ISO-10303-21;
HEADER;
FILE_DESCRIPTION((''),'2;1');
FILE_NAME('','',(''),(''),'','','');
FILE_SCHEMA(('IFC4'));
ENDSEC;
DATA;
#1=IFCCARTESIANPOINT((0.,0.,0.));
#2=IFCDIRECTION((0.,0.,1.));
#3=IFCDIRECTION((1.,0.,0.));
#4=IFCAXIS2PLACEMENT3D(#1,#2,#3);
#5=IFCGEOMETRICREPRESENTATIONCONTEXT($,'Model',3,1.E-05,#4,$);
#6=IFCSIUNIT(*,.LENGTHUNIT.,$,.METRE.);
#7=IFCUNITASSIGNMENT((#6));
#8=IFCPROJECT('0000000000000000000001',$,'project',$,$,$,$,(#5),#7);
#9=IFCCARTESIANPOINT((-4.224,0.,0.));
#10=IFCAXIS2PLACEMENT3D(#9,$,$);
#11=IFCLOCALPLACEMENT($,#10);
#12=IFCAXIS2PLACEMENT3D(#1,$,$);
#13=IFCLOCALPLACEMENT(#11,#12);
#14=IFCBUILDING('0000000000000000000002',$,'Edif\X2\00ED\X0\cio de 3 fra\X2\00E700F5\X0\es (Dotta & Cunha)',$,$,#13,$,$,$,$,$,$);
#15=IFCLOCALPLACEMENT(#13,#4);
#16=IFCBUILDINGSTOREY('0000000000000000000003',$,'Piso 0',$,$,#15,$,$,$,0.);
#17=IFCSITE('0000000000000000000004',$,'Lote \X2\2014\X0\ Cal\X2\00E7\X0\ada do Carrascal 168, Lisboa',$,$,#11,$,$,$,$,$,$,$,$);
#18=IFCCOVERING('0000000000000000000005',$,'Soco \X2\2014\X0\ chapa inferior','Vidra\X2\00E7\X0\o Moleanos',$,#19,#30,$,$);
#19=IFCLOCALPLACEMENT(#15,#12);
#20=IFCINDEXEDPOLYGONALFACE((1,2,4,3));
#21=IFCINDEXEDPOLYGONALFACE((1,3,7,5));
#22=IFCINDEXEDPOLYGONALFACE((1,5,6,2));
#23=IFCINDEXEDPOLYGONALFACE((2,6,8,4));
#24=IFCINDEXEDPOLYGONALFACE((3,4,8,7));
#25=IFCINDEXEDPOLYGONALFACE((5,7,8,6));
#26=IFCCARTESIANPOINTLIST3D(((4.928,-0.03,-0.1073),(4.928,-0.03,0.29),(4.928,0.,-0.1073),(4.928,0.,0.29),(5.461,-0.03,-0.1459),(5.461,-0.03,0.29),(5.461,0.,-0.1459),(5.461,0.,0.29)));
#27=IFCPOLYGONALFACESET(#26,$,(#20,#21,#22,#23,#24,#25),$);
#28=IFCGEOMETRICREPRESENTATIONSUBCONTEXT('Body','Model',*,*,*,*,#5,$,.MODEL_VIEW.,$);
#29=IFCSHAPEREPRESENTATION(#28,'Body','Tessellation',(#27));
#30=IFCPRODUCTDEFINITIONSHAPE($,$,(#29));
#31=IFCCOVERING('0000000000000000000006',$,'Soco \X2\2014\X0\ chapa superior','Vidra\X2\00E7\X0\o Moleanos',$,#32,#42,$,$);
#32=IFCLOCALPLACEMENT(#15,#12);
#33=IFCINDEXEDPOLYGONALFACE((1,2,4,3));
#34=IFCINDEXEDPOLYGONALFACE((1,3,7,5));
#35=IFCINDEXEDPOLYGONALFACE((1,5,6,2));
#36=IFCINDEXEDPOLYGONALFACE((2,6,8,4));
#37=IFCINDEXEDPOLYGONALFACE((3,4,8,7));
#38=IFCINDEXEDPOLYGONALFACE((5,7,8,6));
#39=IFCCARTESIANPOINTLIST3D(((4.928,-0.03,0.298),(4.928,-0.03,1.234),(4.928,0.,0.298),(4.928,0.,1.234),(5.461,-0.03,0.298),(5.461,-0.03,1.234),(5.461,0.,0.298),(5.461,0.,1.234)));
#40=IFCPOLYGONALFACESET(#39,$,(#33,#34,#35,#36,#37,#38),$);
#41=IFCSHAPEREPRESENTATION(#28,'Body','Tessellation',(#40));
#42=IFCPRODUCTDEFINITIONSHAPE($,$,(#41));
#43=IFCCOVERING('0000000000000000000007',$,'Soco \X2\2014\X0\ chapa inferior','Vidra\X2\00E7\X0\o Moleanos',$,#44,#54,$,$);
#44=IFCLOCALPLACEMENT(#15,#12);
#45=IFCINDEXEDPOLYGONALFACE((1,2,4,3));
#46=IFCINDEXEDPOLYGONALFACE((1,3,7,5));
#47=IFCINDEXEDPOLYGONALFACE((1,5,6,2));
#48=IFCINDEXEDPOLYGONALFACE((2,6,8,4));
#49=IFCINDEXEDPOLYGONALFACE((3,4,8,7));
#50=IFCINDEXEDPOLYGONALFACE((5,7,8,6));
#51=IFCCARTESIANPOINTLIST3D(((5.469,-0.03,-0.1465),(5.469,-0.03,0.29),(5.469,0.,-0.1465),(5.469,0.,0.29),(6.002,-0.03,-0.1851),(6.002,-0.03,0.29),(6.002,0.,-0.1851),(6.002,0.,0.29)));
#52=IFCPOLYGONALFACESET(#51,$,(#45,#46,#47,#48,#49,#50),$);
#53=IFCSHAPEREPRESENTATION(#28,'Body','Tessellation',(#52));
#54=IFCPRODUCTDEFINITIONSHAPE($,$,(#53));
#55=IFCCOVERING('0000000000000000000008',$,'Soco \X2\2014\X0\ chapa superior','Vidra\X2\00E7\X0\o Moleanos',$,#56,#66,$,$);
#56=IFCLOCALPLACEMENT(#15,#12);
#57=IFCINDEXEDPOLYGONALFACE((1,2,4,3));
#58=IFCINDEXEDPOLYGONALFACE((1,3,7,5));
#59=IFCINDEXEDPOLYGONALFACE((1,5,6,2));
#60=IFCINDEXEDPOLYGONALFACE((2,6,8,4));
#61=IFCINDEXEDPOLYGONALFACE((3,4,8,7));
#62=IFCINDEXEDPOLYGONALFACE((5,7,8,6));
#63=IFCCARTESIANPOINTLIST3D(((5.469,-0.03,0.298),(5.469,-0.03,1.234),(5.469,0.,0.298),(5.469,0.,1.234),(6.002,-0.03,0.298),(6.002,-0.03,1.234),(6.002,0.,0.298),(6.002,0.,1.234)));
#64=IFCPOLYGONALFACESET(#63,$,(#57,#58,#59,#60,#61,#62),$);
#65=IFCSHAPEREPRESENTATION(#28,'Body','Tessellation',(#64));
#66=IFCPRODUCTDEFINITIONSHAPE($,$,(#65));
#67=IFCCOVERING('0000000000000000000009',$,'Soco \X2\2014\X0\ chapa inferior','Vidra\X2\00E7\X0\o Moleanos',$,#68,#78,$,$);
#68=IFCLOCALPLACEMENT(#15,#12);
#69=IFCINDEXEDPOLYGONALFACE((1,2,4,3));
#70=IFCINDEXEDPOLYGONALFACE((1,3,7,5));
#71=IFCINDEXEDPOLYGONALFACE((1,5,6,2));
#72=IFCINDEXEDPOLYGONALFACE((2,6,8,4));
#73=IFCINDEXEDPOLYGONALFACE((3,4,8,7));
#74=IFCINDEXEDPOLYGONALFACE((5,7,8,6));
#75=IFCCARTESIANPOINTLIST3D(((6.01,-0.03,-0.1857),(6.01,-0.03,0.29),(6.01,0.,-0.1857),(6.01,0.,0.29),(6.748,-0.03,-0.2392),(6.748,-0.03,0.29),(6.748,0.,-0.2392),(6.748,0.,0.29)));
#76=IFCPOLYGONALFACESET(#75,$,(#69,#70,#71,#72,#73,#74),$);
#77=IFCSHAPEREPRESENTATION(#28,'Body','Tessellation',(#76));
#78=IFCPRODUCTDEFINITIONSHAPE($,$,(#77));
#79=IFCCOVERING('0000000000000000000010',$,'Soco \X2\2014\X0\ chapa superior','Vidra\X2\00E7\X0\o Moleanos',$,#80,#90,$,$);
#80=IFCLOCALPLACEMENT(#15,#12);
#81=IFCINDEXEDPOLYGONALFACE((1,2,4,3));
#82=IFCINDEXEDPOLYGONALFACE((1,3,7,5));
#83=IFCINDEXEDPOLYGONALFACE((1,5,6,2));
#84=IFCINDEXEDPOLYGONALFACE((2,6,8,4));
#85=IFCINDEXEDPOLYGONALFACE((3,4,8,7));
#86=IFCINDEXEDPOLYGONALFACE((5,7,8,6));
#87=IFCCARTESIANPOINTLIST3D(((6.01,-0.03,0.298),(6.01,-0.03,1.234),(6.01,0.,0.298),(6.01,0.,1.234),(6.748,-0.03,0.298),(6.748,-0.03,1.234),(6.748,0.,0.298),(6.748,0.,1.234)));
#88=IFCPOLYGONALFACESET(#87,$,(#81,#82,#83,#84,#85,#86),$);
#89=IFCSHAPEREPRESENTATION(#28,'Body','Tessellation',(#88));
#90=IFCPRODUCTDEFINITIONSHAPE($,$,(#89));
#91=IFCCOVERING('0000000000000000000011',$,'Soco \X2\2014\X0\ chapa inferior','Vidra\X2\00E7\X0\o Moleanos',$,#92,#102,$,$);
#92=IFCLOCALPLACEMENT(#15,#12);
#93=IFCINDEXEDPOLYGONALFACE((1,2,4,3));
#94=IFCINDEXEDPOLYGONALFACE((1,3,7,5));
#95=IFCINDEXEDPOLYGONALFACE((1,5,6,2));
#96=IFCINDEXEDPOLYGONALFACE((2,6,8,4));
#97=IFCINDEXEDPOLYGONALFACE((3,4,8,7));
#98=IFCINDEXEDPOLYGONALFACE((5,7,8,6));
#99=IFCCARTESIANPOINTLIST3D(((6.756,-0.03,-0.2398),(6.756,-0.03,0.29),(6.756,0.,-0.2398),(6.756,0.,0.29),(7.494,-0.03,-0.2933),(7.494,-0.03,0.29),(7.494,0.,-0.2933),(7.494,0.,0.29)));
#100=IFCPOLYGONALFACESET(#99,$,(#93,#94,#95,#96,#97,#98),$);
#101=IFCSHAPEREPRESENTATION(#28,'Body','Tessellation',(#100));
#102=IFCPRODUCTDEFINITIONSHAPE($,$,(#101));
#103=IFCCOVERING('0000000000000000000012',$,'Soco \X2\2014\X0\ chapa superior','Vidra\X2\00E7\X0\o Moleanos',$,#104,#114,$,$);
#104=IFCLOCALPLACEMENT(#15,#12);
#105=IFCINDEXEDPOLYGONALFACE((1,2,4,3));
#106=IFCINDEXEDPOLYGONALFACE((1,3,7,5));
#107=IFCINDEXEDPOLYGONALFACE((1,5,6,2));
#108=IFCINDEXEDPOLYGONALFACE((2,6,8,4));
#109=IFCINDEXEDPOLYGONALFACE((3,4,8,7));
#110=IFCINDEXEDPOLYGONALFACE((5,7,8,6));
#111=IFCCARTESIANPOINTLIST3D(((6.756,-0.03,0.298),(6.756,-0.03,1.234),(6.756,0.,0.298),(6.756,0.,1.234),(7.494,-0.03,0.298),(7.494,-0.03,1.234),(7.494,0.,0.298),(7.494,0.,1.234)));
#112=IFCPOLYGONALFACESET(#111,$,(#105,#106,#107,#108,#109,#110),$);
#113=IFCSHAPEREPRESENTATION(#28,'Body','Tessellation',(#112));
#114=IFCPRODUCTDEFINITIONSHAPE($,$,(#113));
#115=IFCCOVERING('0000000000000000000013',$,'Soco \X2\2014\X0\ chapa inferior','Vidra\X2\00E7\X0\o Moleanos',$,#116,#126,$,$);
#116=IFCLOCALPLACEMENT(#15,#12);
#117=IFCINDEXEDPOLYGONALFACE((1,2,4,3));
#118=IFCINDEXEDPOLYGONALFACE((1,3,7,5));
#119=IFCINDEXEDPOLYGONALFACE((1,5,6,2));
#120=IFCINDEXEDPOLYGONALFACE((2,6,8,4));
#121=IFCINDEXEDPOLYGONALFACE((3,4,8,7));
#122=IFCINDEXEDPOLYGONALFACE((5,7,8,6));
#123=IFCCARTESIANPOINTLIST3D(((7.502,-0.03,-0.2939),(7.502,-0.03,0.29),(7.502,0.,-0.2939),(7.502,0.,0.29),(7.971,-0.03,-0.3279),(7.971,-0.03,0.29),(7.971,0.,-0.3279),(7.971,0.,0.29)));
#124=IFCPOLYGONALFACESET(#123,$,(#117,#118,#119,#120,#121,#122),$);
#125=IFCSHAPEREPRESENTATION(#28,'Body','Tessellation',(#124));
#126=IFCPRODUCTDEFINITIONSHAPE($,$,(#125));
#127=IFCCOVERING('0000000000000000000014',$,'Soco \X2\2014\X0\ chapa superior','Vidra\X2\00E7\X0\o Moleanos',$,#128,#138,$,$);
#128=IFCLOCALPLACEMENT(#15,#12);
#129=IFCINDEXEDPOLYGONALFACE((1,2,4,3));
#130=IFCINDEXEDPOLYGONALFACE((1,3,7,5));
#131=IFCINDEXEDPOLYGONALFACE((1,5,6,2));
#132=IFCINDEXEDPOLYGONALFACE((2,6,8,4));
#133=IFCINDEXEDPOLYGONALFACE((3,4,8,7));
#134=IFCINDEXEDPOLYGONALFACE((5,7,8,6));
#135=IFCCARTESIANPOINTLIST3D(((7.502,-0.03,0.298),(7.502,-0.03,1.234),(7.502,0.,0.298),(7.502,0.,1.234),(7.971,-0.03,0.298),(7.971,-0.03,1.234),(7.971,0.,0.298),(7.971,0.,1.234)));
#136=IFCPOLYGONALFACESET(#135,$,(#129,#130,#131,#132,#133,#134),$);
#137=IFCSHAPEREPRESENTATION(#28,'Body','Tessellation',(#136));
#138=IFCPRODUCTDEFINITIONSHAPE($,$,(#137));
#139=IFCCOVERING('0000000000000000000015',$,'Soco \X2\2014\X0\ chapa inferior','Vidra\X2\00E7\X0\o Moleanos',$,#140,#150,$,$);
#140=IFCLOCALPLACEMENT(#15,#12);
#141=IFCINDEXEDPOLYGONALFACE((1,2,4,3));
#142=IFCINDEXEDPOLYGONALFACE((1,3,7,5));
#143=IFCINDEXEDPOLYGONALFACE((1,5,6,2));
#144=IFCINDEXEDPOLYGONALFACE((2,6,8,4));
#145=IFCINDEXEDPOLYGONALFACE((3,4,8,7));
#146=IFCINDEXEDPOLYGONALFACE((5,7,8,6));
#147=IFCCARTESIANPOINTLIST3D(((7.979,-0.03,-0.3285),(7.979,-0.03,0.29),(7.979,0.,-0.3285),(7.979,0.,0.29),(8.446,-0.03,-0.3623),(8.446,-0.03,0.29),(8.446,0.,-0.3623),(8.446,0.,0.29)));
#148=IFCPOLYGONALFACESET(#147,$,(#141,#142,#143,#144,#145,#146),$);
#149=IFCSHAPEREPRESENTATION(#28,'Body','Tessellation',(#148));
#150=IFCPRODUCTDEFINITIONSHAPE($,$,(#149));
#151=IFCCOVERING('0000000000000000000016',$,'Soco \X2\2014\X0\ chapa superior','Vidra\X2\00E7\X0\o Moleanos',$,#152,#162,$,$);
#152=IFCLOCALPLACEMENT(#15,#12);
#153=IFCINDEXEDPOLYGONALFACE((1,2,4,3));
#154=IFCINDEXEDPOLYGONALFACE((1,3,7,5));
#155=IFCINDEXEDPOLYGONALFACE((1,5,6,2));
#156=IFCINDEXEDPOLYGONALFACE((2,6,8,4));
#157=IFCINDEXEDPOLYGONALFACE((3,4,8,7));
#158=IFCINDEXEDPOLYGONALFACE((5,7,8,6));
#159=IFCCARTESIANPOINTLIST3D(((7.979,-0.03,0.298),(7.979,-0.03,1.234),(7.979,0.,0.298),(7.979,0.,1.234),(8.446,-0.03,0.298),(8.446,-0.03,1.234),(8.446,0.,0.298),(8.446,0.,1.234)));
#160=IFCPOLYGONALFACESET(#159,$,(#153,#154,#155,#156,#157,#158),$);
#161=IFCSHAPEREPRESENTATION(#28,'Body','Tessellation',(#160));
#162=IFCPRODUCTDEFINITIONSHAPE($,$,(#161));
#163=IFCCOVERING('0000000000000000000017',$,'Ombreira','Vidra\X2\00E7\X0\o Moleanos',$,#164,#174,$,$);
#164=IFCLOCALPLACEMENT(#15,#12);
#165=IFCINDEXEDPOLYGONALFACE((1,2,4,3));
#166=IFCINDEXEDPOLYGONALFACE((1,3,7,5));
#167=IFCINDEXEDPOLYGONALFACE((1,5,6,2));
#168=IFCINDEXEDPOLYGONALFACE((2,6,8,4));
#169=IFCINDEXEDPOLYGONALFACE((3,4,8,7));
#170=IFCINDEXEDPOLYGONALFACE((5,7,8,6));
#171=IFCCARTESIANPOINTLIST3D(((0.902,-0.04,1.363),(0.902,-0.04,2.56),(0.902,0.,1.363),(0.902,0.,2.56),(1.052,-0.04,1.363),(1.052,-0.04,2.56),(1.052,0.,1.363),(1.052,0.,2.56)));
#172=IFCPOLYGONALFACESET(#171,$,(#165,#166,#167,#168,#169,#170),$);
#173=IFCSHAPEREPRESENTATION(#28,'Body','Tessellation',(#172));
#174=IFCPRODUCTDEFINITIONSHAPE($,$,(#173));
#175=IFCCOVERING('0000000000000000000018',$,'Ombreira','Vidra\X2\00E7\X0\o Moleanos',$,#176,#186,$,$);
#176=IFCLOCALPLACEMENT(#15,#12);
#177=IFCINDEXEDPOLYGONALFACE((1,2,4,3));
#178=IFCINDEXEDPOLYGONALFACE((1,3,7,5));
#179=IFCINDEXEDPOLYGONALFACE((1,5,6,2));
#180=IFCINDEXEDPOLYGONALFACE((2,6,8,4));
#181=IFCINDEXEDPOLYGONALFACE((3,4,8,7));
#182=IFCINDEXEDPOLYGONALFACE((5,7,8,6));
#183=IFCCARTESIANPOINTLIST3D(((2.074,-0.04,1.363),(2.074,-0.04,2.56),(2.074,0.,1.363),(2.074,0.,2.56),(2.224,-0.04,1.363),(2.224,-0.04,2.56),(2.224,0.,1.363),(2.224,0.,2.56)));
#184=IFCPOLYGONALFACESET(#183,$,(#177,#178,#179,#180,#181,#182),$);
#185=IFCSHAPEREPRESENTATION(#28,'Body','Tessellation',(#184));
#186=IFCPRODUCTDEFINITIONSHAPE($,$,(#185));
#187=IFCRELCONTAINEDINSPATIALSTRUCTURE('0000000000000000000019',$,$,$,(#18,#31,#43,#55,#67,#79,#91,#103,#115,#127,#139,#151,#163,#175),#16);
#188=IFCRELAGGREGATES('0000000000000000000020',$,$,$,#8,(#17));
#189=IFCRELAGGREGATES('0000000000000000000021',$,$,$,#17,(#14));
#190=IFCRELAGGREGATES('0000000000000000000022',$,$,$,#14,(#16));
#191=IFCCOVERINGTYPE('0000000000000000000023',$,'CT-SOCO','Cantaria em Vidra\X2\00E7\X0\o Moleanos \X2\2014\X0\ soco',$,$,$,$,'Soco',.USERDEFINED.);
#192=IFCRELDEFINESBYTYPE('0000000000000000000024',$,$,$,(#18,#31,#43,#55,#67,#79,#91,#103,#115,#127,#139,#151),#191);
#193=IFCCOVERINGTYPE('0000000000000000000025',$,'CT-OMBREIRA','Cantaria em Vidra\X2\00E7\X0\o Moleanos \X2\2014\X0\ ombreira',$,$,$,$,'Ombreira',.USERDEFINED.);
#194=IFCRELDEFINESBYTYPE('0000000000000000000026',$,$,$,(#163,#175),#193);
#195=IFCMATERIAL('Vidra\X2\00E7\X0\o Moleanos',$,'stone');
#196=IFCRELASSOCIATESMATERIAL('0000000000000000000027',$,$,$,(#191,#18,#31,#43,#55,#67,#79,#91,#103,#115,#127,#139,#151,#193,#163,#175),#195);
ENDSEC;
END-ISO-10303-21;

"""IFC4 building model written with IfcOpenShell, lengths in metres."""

from ifc_helpers import new_model, si_unit, frame, origin, origin_with_axes, place, context, subcontext, project, spatial, line, indexed_curve, outline, extrude, material, type_object, element, save


model = new_model("IFC4")

# Units and contexts
model_context = context("Model", 3, precision=1e-05, world=origin_with_axes())
body_context = subcontext(model_context, "Body", "Model", "MODEL_VIEW")
ifc_project = project(units=[si_unit("LENGTHUNIT", "METRE")], contexts=[model_context])

# Site, building, storey
site_placement = place(None, frame((-4.224, 0.0, 0.0)))
site = spatial("IfcSite", under=ifc_project, at=site_placement, Name="Lote — Calçada do Carrascal 168, Lisboa")
building_placement = place(site_placement, origin())
building = spatial("IfcBuilding", under=site, at=building_placement, Name="Edifício de 3 frações (Dotta & Cunha)")
storey_placement = place(building_placement, origin_with_axes())
storey = spatial("IfcBuildingStorey", under=building, at=storey_placement, Name="Piso 0", Elevation=0.0)

# Coverings
ifc_material = material(Name="Vidraço Moleanos", Category="stone")
covering_type_1 = type_object("IfcCoveringType", Name="CT-SOCO", Description="Cantaria em Vidraço Moleanos — soco", ElementType="Soco", PredefinedType="USERDEFINED", material=ifc_material)
covering_1_placement = place(storey_placement, frame((0.0, 0.0, 0.0), z_axis=(0.0, -1.0, 0.0), x_axis=(1.0, 0.0, 0.0)))
element("IfcCovering", 1, at=covering_1_placement, inside=storey, type_object=covering_type_1, material=ifc_material, Name="Soco — chapa inferior", Description="Vidraço Moleanos", context=body_context, shape_type="SweptSolid", body=[
    extrude(outline(indexed_curve([(4.928, -0.1073), (5.461, -0.1459), (5.461, 0.29), (4.928, 0.29)], segments=[line(1, 2, 3, 4, 1)])), origin_with_axes(), (0.0, 0.0, 1.0), 0.03),
])
covering_2_placement = place(storey_placement, frame((0.0, 0.0, 0.0), z_axis=(0.0, -1.0, 0.0), x_axis=(1.0, 0.0, 0.0)))
element("IfcCovering", 2, at=covering_2_placement, inside=storey, type_object=covering_type_1, material=ifc_material, Name="Soco — chapa superior", Description="Vidraço Moleanos", context=body_context, shape_type="SweptSolid", body=[
    extrude(outline(indexed_curve([(5.461, 0.298), (5.461, 1.234), (4.928, 1.234), (4.928, 0.298)], segments=[line(1, 2, 3, 4, 1)])), origin_with_axes(), (0.0, 0.0, 1.0), 0.03),
])
covering_3_placement = place(storey_placement, frame((0.0, 0.0, 0.0), z_axis=(0.0, -1.0, 0.0), x_axis=(1.0, 0.0, 0.0)))
element("IfcCovering", 3, at=covering_3_placement, inside=storey, type_object=covering_type_1, material=ifc_material, Name="Soco — chapa inferior", Description="Vidraço Moleanos", context=body_context, shape_type="SweptSolid", body=[
    extrude(outline(indexed_curve([(5.469, -0.1465), (6.002, -0.1851), (6.002, 0.29), (5.469, 0.29)], segments=[line(1, 2, 3, 4, 1)])), origin_with_axes(), (0.0, 0.0, 1.0), 0.03),
])
covering_4_placement = place(storey_placement, frame((0.0, 0.0, 0.0), z_axis=(0.0, -1.0, 0.0), x_axis=(1.0, 0.0, 0.0)))
element("IfcCovering", 4, at=covering_4_placement, inside=storey, type_object=covering_type_1, material=ifc_material, Name="Soco — chapa superior", Description="Vidraço Moleanos", context=body_context, shape_type="SweptSolid", body=[
    extrude(outline(indexed_curve([(6.002, 0.298), (6.002, 1.234), (5.469, 1.234), (5.469, 0.298)], segments=[line(1, 2, 3, 4, 1)])), origin_with_axes(), (0.0, 0.0, 1.0), 0.03),
])
covering_5_placement = place(storey_placement, frame((0.0, 0.0, 0.0), z_axis=(0.0, -1.0, 0.0), x_axis=(1.0, 0.0, 0.0)))
element("IfcCovering", 5, at=covering_5_placement, inside=storey, type_object=covering_type_1, material=ifc_material, Name="Soco — chapa inferior", Description="Vidraço Moleanos", context=body_context, shape_type="SweptSolid", body=[
    extrude(outline(indexed_curve([(6.01, -0.1857), (6.748, -0.2392), (6.748, 0.29), (6.01, 0.29)], segments=[line(1, 2, 3, 4, 1)])), origin_with_axes(), (0.0, 0.0, 1.0), 0.03),
])
covering_6_placement = place(storey_placement, frame((0.0, 0.0, 0.0), z_axis=(0.0, -1.0, 0.0), x_axis=(1.0, 0.0, 0.0)))
element("IfcCovering", 6, at=covering_6_placement, inside=storey, type_object=covering_type_1, material=ifc_material, Name="Soco — chapa superior", Description="Vidraço Moleanos", context=body_context, shape_type="SweptSolid", body=[
    extrude(outline(indexed_curve([(6.748, 0.298), (6.748, 1.234), (6.01, 1.234), (6.01, 0.298)], segments=[line(1, 2, 3, 4, 1)])), origin_with_axes(), (0.0, 0.0, 1.0), 0.03),
])
covering_7_placement = place(storey_placement, frame((0.0, 0.0, 0.0), z_axis=(0.0, -1.0, 0.0), x_axis=(1.0, 0.0, 0.0)))
element("IfcCovering", 7, at=covering_7_placement, inside=storey, type_object=covering_type_1, material=ifc_material, Name="Soco — chapa inferior", Description="Vidraço Moleanos", context=body_context, shape_type="SweptSolid", body=[
    extrude(outline(indexed_curve([(6.756, -0.2398), (7.494, -0.2933), (7.494, 0.29), (6.756, 0.29)], segments=[line(1, 2, 3, 4, 1)])), origin_with_axes(), (0.0, 0.0, 1.0), 0.03),
])
covering_8_placement = place(storey_placement, frame((0.0, 0.0, 0.0), z_axis=(0.0, -1.0, 0.0), x_axis=(1.0, 0.0, 0.0)))
element("IfcCovering", 8, at=covering_8_placement, inside=storey, type_object=covering_type_1, material=ifc_material, Name="Soco — chapa superior", Description="Vidraço Moleanos", context=body_context, shape_type="SweptSolid", body=[
    extrude(outline(indexed_curve([(7.494, 0.298), (7.494, 1.234), (6.756, 1.234), (6.756, 0.298)], segments=[line(1, 2, 3, 4, 1)])), origin_with_axes(), (0.0, 0.0, 1.0), 0.03),
])
covering_9_placement = place(storey_placement, frame((0.0, 0.0, 0.0), z_axis=(0.0, -1.0, 0.0), x_axis=(1.0, 0.0, 0.0)))
element("IfcCovering", 9, at=covering_9_placement, inside=storey, type_object=covering_type_1, material=ifc_material, Name="Soco — chapa inferior", Description="Vidraço Moleanos", context=body_context, shape_type="SweptSolid", body=[
    extrude(outline(indexed_curve([(7.502, -0.2939), (7.971, -0.3279), (7.971, 0.29), (7.502, 0.29)], segments=[line(1, 2, 3, 4, 1)])), origin_with_axes(), (0.0, 0.0, 1.0), 0.03),
])
covering_10_placement = place(storey_placement, frame((0.0, 0.0, 0.0), z_axis=(0.0, -1.0, 0.0), x_axis=(1.0, 0.0, 0.0)))
element("IfcCovering", 10, at=covering_10_placement, inside=storey, type_object=covering_type_1, material=ifc_material, Name="Soco — chapa superior", Description="Vidraço Moleanos", context=body_context, shape_type="SweptSolid", body=[
    extrude(outline(indexed_curve([(7.971, 0.298), (7.971, 1.234), (7.502, 1.234), (7.502, 0.298)], segments=[line(1, 2, 3, 4, 1)])), origin_with_axes(), (0.0, 0.0, 1.0), 0.03),
])
covering_11_placement = place(storey_placement, frame((0.0, 0.0, 0.0), z_axis=(0.0, -1.0, 0.0), x_axis=(1.0, 0.0, 0.0)))
element("IfcCovering", 11, at=covering_11_placement, inside=storey, type_object=covering_type_1, material=ifc_material, Name="Soco — chapa inferior", Description="Vidraço Moleanos", context=body_context, shape_type="SweptSolid", body=[
    extrude(outline(indexed_curve([(7.979, -0.3285), (8.446, -0.3623), (8.446, 0.29), (7.979, 0.29)], segments=[line(1, 2, 3, 4, 1)])), origin_with_axes(), (0.0, 0.0, 1.0), 0.03),
])
covering_12_placement = place(storey_placement, frame((0.0, 0.0, 0.0), z_axis=(0.0, -1.0, 0.0), x_axis=(1.0, 0.0, 0.0)))
element("IfcCovering", 12, at=covering_12_placement, inside=storey, type_object=covering_type_1, material=ifc_material, Name="Soco — chapa superior", Description="Vidraço Moleanos", context=body_context, shape_type="SweptSolid", body=[
    extrude(outline(indexed_curve([(8.446, 0.298), (8.446, 1.234), (7.979, 1.234), (7.979, 0.298)], segments=[line(1, 2, 3, 4, 1)])), origin_with_axes(), (0.0, 0.0, 1.0), 0.03),
])
covering_type_2 = type_object("IfcCoveringType", Name="CT-OMBREIRA", Description="Cantaria em Vidraço Moleanos — ombreira", ElementType="Ombreira", PredefinedType="USERDEFINED", material=ifc_material)
covering_13_placement = place(storey_placement, frame((0.0, 0.0, 0.0), z_axis=(0.0, -1.0, 0.0), x_axis=(1.0, 0.0, 0.0)))
element("IfcCovering", 13, at=covering_13_placement, inside=storey, type_object=covering_type_2, material=ifc_material, Name="Ombreira", Description="Vidraço Moleanos", context=body_context, shape_type="SweptSolid", body=[
    extrude(outline(indexed_curve([(1.052, 1.363), (1.052, 2.56), (0.902, 2.56), (0.902, 1.363)], segments=[line(1, 2, 3, 4, 1)])), origin_with_axes(), (0.0, 0.0, 1.0), 0.04),
])
covering_14_placement = place(storey_placement, frame((0.0, 0.0, 0.0), z_axis=(0.0, -1.0, 0.0), x_axis=(1.0, 0.0, 0.0)))
element("IfcCovering", 14, at=covering_14_placement, inside=storey, type_object=covering_type_2, material=ifc_material, Name="Ombreira", Description="Vidraço Moleanos", context=body_context, shape_type="SweptSolid", body=[
    extrude(outline(indexed_curve([(2.224, 1.363), (2.224, 2.56), (2.074, 2.56), (2.074, 1.363)], segments=[line(1, 2, 3, 4, 1)])), origin_with_axes(), (0.0, 0.0, 1.0), 0.04),
])

save(model, "model.ifc")
